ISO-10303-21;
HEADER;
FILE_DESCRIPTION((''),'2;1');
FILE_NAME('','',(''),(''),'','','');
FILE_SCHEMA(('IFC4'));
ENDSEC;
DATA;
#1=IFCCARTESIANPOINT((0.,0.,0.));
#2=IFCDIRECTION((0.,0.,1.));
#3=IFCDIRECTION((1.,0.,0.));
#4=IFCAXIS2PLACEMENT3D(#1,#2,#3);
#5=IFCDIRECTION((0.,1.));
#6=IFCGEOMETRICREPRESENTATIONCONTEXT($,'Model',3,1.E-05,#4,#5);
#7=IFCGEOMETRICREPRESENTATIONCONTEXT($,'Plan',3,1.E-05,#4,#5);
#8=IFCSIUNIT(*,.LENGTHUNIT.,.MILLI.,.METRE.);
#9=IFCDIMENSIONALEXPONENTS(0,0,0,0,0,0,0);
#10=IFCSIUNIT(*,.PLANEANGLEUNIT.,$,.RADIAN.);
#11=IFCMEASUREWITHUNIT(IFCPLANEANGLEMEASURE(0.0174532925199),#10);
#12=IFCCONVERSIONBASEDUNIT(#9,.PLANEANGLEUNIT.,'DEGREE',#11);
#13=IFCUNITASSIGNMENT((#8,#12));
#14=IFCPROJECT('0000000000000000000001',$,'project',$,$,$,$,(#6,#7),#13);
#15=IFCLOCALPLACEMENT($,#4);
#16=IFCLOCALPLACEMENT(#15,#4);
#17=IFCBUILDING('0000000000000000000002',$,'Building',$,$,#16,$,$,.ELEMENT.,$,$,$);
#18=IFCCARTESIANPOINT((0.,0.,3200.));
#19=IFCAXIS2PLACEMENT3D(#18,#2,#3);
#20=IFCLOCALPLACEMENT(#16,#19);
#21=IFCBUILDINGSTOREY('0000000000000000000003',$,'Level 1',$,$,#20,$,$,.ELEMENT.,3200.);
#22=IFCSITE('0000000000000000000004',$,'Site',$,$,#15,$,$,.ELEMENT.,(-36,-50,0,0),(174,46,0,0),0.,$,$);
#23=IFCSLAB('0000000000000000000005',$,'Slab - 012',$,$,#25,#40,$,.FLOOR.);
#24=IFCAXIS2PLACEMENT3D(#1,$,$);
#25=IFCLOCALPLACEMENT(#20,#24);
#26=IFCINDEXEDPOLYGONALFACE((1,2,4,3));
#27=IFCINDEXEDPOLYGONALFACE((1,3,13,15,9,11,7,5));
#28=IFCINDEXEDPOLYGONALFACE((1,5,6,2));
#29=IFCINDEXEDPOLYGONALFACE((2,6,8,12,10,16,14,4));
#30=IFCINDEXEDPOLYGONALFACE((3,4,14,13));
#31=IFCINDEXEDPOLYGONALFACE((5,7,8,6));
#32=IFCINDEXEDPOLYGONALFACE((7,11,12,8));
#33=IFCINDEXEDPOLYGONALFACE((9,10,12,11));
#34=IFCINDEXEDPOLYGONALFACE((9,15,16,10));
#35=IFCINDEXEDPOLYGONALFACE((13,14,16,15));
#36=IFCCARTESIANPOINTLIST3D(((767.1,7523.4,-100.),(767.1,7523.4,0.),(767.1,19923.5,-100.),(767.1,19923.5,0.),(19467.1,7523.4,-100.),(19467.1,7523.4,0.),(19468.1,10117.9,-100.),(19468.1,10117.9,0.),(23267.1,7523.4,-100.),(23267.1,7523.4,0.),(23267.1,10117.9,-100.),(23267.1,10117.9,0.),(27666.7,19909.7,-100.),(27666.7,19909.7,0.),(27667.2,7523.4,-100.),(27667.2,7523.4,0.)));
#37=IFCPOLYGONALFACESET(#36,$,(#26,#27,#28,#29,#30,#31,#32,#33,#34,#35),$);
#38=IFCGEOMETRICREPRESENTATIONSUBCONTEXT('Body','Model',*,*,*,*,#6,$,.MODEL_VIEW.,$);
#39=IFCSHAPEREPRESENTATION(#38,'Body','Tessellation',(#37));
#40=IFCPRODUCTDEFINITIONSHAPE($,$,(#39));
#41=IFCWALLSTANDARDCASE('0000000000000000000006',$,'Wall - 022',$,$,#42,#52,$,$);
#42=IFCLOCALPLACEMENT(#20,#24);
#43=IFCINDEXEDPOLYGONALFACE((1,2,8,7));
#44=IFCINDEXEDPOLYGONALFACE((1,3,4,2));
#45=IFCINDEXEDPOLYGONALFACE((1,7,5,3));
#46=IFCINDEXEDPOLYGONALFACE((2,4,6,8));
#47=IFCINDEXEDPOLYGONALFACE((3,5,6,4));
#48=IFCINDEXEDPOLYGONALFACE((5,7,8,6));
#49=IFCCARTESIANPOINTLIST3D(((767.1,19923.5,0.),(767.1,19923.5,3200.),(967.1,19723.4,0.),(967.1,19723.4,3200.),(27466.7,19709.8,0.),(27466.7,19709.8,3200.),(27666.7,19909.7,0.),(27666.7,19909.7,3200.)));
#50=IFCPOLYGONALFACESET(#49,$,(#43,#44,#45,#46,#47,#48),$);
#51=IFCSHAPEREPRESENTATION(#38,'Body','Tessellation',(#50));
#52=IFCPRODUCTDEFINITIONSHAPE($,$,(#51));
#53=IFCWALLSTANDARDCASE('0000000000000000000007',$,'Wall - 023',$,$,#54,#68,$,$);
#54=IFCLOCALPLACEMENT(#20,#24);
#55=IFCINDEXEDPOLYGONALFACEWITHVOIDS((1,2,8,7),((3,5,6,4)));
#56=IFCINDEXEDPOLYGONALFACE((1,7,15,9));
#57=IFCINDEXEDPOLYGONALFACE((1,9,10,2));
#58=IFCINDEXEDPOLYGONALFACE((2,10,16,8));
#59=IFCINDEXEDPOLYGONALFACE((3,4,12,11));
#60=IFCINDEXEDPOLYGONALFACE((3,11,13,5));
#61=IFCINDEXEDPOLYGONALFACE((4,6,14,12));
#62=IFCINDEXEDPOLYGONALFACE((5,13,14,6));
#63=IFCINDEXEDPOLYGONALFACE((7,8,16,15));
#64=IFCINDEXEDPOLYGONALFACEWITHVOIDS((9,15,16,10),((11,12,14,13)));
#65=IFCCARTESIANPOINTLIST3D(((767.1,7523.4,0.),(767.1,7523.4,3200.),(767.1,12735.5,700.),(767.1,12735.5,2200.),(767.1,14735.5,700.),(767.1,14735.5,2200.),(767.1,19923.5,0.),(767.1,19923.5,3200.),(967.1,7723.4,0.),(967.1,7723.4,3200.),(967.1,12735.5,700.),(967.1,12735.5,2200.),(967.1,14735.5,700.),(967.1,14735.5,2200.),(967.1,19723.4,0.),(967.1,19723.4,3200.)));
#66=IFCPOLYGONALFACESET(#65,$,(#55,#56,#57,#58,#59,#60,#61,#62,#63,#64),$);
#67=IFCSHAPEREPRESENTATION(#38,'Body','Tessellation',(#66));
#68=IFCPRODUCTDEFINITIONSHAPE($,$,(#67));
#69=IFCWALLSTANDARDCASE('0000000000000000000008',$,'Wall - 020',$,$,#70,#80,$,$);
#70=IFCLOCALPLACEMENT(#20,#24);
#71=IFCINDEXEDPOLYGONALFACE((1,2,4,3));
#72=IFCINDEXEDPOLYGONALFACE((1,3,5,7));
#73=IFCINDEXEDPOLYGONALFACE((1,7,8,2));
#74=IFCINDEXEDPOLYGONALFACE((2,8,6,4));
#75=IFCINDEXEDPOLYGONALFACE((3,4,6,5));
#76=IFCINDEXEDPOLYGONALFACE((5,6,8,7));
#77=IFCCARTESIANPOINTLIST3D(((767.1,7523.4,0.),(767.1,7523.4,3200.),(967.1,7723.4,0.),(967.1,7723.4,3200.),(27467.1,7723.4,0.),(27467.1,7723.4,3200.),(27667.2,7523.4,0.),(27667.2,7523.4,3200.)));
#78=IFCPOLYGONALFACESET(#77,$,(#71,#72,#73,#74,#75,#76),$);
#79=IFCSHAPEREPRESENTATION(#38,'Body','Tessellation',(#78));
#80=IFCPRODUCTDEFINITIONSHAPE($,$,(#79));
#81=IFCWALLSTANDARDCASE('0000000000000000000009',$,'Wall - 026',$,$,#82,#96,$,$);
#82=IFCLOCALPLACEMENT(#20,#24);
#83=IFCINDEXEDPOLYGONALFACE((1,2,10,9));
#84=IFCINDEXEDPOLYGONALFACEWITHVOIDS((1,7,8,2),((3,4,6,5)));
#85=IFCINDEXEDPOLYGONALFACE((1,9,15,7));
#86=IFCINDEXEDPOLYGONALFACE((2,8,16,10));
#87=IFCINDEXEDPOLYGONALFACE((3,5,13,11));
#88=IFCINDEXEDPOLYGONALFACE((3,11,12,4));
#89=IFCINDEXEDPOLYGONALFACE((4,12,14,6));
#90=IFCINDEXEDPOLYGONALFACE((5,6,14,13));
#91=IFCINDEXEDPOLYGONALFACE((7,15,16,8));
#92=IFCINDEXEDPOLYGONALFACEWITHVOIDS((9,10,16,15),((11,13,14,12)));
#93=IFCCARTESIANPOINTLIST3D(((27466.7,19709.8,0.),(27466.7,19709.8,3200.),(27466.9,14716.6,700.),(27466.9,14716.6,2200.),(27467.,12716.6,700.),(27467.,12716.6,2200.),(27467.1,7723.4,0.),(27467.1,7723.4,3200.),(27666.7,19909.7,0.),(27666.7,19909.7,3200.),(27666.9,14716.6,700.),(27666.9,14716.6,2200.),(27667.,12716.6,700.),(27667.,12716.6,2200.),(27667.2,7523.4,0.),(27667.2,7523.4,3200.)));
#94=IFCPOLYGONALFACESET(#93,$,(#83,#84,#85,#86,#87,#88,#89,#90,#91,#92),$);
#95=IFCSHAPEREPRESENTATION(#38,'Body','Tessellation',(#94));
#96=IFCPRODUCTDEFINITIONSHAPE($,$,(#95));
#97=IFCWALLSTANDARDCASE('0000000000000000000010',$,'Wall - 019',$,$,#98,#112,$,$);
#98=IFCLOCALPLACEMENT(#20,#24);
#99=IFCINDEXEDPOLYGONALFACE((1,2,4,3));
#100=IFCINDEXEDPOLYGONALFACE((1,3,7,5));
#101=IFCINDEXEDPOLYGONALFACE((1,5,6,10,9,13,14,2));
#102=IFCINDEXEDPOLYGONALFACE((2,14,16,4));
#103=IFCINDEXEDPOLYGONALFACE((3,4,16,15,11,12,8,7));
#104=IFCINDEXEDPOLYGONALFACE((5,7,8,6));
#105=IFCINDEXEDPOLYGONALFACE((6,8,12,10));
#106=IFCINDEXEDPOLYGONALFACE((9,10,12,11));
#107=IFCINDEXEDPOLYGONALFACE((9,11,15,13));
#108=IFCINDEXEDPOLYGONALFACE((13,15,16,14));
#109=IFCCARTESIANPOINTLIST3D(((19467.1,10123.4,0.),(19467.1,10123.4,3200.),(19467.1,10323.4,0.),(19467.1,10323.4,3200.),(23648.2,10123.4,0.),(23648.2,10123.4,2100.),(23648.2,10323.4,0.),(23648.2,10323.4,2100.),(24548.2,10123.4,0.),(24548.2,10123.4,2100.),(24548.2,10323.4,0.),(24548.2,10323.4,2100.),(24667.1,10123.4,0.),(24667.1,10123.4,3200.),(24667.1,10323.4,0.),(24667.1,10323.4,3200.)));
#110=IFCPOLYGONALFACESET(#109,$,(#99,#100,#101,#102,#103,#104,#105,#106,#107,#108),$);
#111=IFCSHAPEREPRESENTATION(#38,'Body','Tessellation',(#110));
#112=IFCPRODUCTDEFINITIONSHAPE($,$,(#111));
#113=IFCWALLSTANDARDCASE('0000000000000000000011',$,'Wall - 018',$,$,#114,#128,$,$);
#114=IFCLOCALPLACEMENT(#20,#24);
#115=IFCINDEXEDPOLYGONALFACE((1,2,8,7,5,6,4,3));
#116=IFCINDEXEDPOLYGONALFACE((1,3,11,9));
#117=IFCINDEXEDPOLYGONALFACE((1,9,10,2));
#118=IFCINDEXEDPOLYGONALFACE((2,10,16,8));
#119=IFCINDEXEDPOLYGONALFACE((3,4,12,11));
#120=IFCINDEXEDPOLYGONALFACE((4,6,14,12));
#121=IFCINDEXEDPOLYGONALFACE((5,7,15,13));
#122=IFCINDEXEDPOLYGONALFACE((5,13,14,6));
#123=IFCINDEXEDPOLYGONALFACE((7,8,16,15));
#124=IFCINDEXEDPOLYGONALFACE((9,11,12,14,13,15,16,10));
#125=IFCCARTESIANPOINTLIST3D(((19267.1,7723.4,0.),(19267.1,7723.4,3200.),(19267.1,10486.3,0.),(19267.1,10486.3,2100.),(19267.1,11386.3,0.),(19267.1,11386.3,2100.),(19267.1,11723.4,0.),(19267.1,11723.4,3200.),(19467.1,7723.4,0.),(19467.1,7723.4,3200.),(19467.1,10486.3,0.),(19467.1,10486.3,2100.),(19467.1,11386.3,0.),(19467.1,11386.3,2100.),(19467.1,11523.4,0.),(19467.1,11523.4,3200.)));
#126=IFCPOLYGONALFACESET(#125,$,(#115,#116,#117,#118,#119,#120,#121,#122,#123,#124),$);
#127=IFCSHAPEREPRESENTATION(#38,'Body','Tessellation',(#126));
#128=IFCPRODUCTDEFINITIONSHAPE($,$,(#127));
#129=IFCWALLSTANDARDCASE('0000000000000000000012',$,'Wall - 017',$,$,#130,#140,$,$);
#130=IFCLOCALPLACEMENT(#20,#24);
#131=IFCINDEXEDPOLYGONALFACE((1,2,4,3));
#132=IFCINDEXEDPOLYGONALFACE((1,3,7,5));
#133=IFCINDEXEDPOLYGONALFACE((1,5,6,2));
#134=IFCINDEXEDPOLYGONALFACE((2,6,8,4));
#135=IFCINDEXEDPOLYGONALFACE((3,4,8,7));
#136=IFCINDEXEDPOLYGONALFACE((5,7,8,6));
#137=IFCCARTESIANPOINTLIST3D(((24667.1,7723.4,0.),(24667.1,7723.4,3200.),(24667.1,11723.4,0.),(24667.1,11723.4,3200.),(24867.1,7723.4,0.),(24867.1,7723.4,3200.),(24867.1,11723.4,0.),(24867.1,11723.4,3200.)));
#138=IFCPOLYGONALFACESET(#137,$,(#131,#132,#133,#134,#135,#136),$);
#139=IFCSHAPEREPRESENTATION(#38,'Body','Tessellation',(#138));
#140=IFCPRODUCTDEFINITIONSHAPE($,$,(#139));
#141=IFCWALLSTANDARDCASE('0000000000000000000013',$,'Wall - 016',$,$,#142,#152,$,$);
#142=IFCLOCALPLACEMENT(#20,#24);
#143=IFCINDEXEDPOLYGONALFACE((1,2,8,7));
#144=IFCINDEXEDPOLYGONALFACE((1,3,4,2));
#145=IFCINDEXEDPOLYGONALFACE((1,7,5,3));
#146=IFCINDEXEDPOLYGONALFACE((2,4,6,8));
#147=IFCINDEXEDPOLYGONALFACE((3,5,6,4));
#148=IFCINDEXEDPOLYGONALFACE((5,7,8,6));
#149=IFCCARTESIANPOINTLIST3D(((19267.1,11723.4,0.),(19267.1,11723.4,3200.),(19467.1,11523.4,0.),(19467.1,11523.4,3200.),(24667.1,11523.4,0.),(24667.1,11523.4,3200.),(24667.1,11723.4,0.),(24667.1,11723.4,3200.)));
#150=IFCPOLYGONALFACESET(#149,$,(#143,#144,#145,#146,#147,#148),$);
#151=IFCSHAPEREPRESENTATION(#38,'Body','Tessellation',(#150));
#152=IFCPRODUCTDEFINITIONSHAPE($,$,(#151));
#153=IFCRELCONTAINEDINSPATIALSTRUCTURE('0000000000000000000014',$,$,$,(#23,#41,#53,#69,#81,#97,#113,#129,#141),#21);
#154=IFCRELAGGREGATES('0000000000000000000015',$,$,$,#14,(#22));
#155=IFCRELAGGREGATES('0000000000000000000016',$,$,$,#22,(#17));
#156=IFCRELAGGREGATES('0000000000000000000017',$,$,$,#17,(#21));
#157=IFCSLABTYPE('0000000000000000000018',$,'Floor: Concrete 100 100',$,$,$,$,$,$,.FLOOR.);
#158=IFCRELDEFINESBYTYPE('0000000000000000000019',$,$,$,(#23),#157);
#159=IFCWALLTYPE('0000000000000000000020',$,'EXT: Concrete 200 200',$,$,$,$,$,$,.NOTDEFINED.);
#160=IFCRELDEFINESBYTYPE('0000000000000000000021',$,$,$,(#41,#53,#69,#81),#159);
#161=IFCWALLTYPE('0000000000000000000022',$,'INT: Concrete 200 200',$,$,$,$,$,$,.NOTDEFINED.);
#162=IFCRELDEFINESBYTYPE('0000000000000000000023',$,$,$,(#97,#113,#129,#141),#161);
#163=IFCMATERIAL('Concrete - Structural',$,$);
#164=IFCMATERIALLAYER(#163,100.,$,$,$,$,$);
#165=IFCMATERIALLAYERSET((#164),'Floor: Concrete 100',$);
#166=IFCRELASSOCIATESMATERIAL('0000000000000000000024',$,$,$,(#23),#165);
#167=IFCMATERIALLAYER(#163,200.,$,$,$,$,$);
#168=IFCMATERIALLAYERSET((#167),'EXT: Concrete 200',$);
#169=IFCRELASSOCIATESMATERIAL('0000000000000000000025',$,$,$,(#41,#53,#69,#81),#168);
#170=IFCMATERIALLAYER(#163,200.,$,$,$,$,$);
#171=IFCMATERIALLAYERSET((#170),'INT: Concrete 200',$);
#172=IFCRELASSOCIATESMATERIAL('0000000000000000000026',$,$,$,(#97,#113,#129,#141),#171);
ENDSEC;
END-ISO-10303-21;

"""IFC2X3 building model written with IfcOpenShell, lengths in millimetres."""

from ifc_helpers import new_model, entity, si_unit, converted_unit, direction, frame, origin_with_axes, origin_2d_with_axis, place, context, subcontext, project, spatial, polyline, rectangle, outline, extrude, material, layer, layer_set, layer_usage, type_object, element, save


model = new_model("IFC2X3")

# Units and contexts
model_context = context("Model", 3, precision=1e-05, world=origin_with_axes(), true_north=direction((0.0, 1.0)))
plan_context = context("Plan", 3, precision=1e-05, world=origin_with_axes(), true_north=direction((0.0, 1.0)))
body_context = subcontext(model_context, "Body", "Model", "MODEL_VIEW")
ifc_project = project(units=[si_unit("LENGTHUNIT", "METRE", prefix="MILLI"), converted_unit("PLANEANGLEUNIT", "DEGREE", entity("IfcPlaneAngleMeasure", 0.0174532925199), si_unit("PLANEANGLEUNIT", "RADIAN"), dimensions=[0, 0, 0, 0, 0, 0, 0])], contexts=[model_context, plan_context])

# Site, building, storey
site_placement = place(None, origin_with_axes())
site = spatial("IfcSite", under=ifc_project, at=site_placement, Name="Site", CompositionType="ELEMENT", RefLatitude=(-36, -50, 0, 0), RefLongitude=(174, 46, 0, 0), RefElevation=0.0)
building_placement = place(site_placement, origin_with_axes())
building = spatial("IfcBuilding", under=site, at=building_placement, Name="Building", CompositionType="ELEMENT")
storey_placement = place(building_placement, frame((0.0, 0.0, 3200.0), z_axis=(0.0, 0.0, 1.0), x_axis=(1.0, 0.0, 0.0)))
storey = spatial("IfcBuildingStorey", under=building, at=storey_placement, Name="Level 1", CompositionType="ELEMENT", Elevation=3200.0)

# Slab
ifc_material = material(Name="Concrete - Structural")
ifc_layer_1 = layer(ifc_material, 100.0)
ifc_layer_set_1 = layer_set([ifc_layer_1], Name="Floor: Concrete 100")
ifc_layer_usage_1 = layer_usage(ifc_layer_set_1, "AXIS3", "NEGATIVE", 100.0)
slab_type = type_object("IfcSlabType", Name="Floor: Concrete 100 100", PredefinedType="FLOOR")
slab_placement = place(storey_placement, frame((767.1, 19923.5, 0.0), z_axis=(0.0, 0.0, 1.0), x_axis=(1.0, 0.0, 0.0)))
element("IfcSlab", 1, at=slab_placement, inside=storey, type_object=slab_type, material=ifc_layer_usage_1, Name="Slab - 012", PredefinedType="FLOOR", context=body_context, shape_type="SweptSolid", body=[
    extrude(outline(polyline([(0.0, 0.0), (0.0, -12400.1), (18700.0, -12400.1), (18700.9, -9805.6), (22500.0, -9805.6), (22500.0, -12400.1), (26900.0, -12400.1), (26899.5, -13.8), (0.0, 0.0)])), frame((0.0, 0.0, -100.0), z_axis=(0.0, 0.0, 1.0), x_axis=(1.0, 0.0, 0.0)), (0.0, 0.0, 1.0), 100.0),
])

# Wall
ifc_layer_2 = layer(ifc_material, 200.0)
ifc_layer_set_2 = layer_set([ifc_layer_2], Name="EXT: Concrete 200")
ifc_layer_usage_2 = layer_usage(ifc_layer_set_2, "AXIS2", "POSITIVE", 0.0)
wall_type_1 = type_object("IfcWallType", Name="EXT: Concrete 200 200", PredefinedType="NOTDEFINED")
wall_1_placement = place(storey_placement, frame((967.1, 19723.4, 0.0), z_axis=(0.0, 0.0, 1.0), x_axis=(1.0, -0.000513, 0.0)))
element("IfcWallStandardCase", 2, at=wall_1_placement, inside=storey, type_object=wall_type_1, material=ifc_layer_usage_2, Name="Wall - 022", context=body_context, shape_type="SweptSolid", body=[
    extrude(outline(polyline([(0.0, 0.0), (26499.5, 0.0), (26699.4, 200.0), (-200.1, 200.0), (0.0, 0.0)])), origin_with_axes(), (0.0, 0.0, 1.0), 3200.0),
])

# Wall, opening
ifc_layer_usage_3 = layer_usage(ifc_layer_set_2, "AXIS2", "POSITIVE", -200.0)
wall_2_placement = place(storey_placement, frame((967.1, 19723.4, 0.0), z_axis=(0.0, 0.0, 1.0), x_axis=(0.0, -1.0, 0.0)))
wall_2 = element("IfcWallStandardCase", 3, at=wall_2_placement, inside=storey, type_object=wall_type_1, material=ifc_layer_usage_3, Name="Wall - 023", context=body_context, shape_type="SweptSolid", body=[
    extrude(outline(polyline([(-200.1, -200.0), (12200.0, -200.0), (12000.0, 0.0), (0.0, 0.0), (-200.1, -200.0)])), origin_with_axes(), (0.0, 0.0, 1.0), 3200.0),
])
opening_1_placement = place(wall_2_placement, frame((5988.0, 0.0, 700.0), z_axis=(0.0, 0.0, 1.0), x_axis=(1.0, 0.0, 0.0)))
element("IfcOpeningElement", 4, at=opening_1_placement, cuts=wall_2, context=body_context, shape_type="SweptSolid", body=[
    extrude(rectangle(XDim=2000.0, YDim=1500.0, at=origin_2d_with_axis()), frame((0.0, 200.0, 750.0), z_axis=(0.0, -1.0, 0.0), x_axis=(-1.0, 0.0, 0.0)), (0.0, 0.0, 1.0), 600.0),
])

# Wall
ifc_layer_usage_4 = layer_usage(ifc_layer_set_2, "AXIS2", "POSITIVE", 0.0)
wall_3_placement = place(storey_placement, frame((27667.1, 7723.4, 0.0), z_axis=(0.0, 0.0, 1.0), x_axis=(-1.0, 0.0, 0.0)))
element("IfcWallStandardCase", 5, at=wall_3_placement, inside=storey, type_object=wall_type_1, material=ifc_layer_usage_4, Name="Wall - 020", context=body_context, shape_type="SweptSolid", body=[
    extrude(outline(polyline([(200.0, 0.0), (26700.0, 0.0), (26900.0, 200.0), (0.0, 200.0), (200.0, 0.0)])), origin_with_axes(), (0.0, 0.0, 1.0), 3200.0),
])

# Walls, openings
ifc_layer_usage_5 = layer_usage(ifc_layer_set_2, "AXIS2", "POSITIVE", -200.0)
wall_4_placement = place(storey_placement, frame((27666.7, 19709.7, 0.0), z_axis=(0.0, 0.0, 1.0), x_axis=(0.000039, -1.0, 0.0)))
wall_4 = element("IfcWallStandardCase", 6, at=wall_4_placement, inside=storey, type_object=wall_type_1, material=ifc_layer_usage_5, Name="Wall - 026", context=body_context, shape_type="SweptSolid", body=[
    extrude(outline(polyline([(-0.1, -200.0), (11986.3, -200.0), (12186.3, 0.0), (-200.0, 0.0), (-0.1, -200.0)])), origin_with_axes(), (0.0, 0.0, 1.0), 3200.0),
])
opening_2_placement = place(wall_4_placement, frame((5993.2, 0.0, 700.0), z_axis=(0.0, 0.0, 1.0), x_axis=(1.0, 0.0, 0.0)))
element("IfcOpeningElement", 7, at=opening_2_placement, cuts=wall_4, context=body_context, shape_type="SweptSolid", body=[
    extrude(rectangle(XDim=2000.0, YDim=1500.0, at=origin_2d_with_axis()), frame((0.0, -200.0, 750.0), z_axis=(0.0, 1.0, 0.0), x_axis=(1.0, 0.0, 0.0)), (0.0, 0.0, 1.0), 600.0),
])
ifc_layer_3 = layer(ifc_material, 200.0)
ifc_layer_set_3 = layer_set([ifc_layer_3], Name="INT: Concrete 200")
ifc_layer_usage_6 = layer_usage(ifc_layer_set_3, "AXIS2", "POSITIVE", -200.0)
wall_type_2 = type_object("IfcWallType", Name="INT: Concrete 200 200", PredefinedType="NOTDEFINED")
wall_5_placement = place(storey_placement, frame((19467.1, 10323.4, 0.0), z_axis=(0.0, 0.0, 1.0), x_axis=(1.0, 0.0, 0.0)))
wall_5 = element("IfcWallStandardCase", 8, at=wall_5_placement, inside=storey, type_object=wall_type_2, material=ifc_layer_usage_6, Name="Wall - 019", context=body_context, shape_type="SweptSolid", body=[
    extrude(outline(polyline([(0.0, -200.0), (5200.0, -200.0), (5200.0, 0.0), (0.0, 0.0), (0.0, -200.0)])), origin_with_axes(), (0.0, 0.0, 1.0), 3200.0),
])
opening_3_placement = place(wall_5_placement, frame((4631.0, 0.0, 0.0), z_axis=(0.0, 0.0, 1.0), x_axis=(1.0, 0.0, 0.0)))
element("IfcOpeningElement", 9, at=opening_3_placement, cuts=wall_5, context=body_context, shape_type="SweptSolid", body=[
    extrude(rectangle(XDim=900.0, YDim=2100.0, at=origin_2d_with_axis()), frame((0.0, 200.0, 1050.0), z_axis=(0.0, 1.0, 0.0), x_axis=(1.0, 0.0, 0.0)), (0.0, 0.0, -1.0), 600.0),
])
ifc_layer_usage_7 = layer_usage(ifc_layer_set_3, "AXIS2", "POSITIVE", -200.0)
wall_6_placement = place(storey_placement, frame((19467.1, 11523.4, 0.0), z_axis=(0.0, 0.0, 1.0), x_axis=(0.0, -1.0, 0.0)))
wall_6 = element("IfcWallStandardCase", 10, at=wall_6_placement, inside=storey, type_object=wall_type_2, material=ifc_layer_usage_7, Name="Wall - 018", context=body_context, shape_type="SweptSolid", body=[
    extrude(outline(polyline([(-200.0, -200.0), (3800.0, -200.0), (3800.0, 0.0), (0.0, 0.0), (-200.0, -200.0)])), origin_with_axes(), (0.0, 0.0, 1.0), 3200.0),
])
opening_4_placement = place(wall_6_placement, frame((587.1, 0.0, 0.0), z_axis=(0.0, 0.0, 1.0), x_axis=(1.0, 0.0, 0.0)))
element("IfcOpeningElement", 11, at=opening_4_placement, cuts=wall_6, context=body_context, shape_type="SweptSolid", body=[
    extrude(rectangle(XDim=900.0, YDim=2100.0, at=origin_2d_with_axis()), frame((0.0, -200.0, 1050.0), z_axis=(0.0, 1.0, 0.0), x_axis=(1.0, 0.0, 0.0)), (0.0, 0.0, 1.0), 600.0),
])

# Walls
ifc_layer_usage_8 = layer_usage(ifc_layer_set_3, "AXIS2", "POSITIVE", 0.0)
wall_7_placement = place(storey_placement, frame((24667.1, 11723.4, 0.0), z_axis=(0.0, 0.0, 1.0), x_axis=(0.0, -1.0, 0.0)))
element("IfcWallStandardCase", 12, at=wall_7_placement, inside=storey, type_object=wall_type_2, material=ifc_layer_usage_8, Name="Wall - 017", context=body_context, shape_type="SweptSolid", body=[
    extrude(outline(polyline([(0.0, 0.0), (4000.0, 0.0), (4000.0, 200.0), (0.0, 200.0), (0.0, 0.0)])), origin_with_axes(), (0.0, 0.0, 1.0), 3200.0),
])
ifc_layer_usage_9 = layer_usage(ifc_layer_set_3, "AXIS2", "POSITIVE", 0.0)
wall_8_placement = place(storey_placement, frame((19467.1, 11523.4, 0.0), z_axis=(0.0, 0.0, 1.0), x_axis=(1.0, 0.0, 0.0)))
element("IfcWallStandardCase", 13, at=wall_8_placement, inside=storey, type_object=wall_type_2, material=ifc_layer_usage_9, Name="Wall - 016", context=body_context, shape_type="SweptSolid", body=[
    extrude(outline(polyline([(0.0, 0.0), (5200.0, 0.0), (5200.0, 200.0), (-200.0, 200.0), (0.0, 0.0)])), origin_with_axes(), (0.0, 0.0, 1.0), 3200.0),
])

save(model, "model.ifc")
